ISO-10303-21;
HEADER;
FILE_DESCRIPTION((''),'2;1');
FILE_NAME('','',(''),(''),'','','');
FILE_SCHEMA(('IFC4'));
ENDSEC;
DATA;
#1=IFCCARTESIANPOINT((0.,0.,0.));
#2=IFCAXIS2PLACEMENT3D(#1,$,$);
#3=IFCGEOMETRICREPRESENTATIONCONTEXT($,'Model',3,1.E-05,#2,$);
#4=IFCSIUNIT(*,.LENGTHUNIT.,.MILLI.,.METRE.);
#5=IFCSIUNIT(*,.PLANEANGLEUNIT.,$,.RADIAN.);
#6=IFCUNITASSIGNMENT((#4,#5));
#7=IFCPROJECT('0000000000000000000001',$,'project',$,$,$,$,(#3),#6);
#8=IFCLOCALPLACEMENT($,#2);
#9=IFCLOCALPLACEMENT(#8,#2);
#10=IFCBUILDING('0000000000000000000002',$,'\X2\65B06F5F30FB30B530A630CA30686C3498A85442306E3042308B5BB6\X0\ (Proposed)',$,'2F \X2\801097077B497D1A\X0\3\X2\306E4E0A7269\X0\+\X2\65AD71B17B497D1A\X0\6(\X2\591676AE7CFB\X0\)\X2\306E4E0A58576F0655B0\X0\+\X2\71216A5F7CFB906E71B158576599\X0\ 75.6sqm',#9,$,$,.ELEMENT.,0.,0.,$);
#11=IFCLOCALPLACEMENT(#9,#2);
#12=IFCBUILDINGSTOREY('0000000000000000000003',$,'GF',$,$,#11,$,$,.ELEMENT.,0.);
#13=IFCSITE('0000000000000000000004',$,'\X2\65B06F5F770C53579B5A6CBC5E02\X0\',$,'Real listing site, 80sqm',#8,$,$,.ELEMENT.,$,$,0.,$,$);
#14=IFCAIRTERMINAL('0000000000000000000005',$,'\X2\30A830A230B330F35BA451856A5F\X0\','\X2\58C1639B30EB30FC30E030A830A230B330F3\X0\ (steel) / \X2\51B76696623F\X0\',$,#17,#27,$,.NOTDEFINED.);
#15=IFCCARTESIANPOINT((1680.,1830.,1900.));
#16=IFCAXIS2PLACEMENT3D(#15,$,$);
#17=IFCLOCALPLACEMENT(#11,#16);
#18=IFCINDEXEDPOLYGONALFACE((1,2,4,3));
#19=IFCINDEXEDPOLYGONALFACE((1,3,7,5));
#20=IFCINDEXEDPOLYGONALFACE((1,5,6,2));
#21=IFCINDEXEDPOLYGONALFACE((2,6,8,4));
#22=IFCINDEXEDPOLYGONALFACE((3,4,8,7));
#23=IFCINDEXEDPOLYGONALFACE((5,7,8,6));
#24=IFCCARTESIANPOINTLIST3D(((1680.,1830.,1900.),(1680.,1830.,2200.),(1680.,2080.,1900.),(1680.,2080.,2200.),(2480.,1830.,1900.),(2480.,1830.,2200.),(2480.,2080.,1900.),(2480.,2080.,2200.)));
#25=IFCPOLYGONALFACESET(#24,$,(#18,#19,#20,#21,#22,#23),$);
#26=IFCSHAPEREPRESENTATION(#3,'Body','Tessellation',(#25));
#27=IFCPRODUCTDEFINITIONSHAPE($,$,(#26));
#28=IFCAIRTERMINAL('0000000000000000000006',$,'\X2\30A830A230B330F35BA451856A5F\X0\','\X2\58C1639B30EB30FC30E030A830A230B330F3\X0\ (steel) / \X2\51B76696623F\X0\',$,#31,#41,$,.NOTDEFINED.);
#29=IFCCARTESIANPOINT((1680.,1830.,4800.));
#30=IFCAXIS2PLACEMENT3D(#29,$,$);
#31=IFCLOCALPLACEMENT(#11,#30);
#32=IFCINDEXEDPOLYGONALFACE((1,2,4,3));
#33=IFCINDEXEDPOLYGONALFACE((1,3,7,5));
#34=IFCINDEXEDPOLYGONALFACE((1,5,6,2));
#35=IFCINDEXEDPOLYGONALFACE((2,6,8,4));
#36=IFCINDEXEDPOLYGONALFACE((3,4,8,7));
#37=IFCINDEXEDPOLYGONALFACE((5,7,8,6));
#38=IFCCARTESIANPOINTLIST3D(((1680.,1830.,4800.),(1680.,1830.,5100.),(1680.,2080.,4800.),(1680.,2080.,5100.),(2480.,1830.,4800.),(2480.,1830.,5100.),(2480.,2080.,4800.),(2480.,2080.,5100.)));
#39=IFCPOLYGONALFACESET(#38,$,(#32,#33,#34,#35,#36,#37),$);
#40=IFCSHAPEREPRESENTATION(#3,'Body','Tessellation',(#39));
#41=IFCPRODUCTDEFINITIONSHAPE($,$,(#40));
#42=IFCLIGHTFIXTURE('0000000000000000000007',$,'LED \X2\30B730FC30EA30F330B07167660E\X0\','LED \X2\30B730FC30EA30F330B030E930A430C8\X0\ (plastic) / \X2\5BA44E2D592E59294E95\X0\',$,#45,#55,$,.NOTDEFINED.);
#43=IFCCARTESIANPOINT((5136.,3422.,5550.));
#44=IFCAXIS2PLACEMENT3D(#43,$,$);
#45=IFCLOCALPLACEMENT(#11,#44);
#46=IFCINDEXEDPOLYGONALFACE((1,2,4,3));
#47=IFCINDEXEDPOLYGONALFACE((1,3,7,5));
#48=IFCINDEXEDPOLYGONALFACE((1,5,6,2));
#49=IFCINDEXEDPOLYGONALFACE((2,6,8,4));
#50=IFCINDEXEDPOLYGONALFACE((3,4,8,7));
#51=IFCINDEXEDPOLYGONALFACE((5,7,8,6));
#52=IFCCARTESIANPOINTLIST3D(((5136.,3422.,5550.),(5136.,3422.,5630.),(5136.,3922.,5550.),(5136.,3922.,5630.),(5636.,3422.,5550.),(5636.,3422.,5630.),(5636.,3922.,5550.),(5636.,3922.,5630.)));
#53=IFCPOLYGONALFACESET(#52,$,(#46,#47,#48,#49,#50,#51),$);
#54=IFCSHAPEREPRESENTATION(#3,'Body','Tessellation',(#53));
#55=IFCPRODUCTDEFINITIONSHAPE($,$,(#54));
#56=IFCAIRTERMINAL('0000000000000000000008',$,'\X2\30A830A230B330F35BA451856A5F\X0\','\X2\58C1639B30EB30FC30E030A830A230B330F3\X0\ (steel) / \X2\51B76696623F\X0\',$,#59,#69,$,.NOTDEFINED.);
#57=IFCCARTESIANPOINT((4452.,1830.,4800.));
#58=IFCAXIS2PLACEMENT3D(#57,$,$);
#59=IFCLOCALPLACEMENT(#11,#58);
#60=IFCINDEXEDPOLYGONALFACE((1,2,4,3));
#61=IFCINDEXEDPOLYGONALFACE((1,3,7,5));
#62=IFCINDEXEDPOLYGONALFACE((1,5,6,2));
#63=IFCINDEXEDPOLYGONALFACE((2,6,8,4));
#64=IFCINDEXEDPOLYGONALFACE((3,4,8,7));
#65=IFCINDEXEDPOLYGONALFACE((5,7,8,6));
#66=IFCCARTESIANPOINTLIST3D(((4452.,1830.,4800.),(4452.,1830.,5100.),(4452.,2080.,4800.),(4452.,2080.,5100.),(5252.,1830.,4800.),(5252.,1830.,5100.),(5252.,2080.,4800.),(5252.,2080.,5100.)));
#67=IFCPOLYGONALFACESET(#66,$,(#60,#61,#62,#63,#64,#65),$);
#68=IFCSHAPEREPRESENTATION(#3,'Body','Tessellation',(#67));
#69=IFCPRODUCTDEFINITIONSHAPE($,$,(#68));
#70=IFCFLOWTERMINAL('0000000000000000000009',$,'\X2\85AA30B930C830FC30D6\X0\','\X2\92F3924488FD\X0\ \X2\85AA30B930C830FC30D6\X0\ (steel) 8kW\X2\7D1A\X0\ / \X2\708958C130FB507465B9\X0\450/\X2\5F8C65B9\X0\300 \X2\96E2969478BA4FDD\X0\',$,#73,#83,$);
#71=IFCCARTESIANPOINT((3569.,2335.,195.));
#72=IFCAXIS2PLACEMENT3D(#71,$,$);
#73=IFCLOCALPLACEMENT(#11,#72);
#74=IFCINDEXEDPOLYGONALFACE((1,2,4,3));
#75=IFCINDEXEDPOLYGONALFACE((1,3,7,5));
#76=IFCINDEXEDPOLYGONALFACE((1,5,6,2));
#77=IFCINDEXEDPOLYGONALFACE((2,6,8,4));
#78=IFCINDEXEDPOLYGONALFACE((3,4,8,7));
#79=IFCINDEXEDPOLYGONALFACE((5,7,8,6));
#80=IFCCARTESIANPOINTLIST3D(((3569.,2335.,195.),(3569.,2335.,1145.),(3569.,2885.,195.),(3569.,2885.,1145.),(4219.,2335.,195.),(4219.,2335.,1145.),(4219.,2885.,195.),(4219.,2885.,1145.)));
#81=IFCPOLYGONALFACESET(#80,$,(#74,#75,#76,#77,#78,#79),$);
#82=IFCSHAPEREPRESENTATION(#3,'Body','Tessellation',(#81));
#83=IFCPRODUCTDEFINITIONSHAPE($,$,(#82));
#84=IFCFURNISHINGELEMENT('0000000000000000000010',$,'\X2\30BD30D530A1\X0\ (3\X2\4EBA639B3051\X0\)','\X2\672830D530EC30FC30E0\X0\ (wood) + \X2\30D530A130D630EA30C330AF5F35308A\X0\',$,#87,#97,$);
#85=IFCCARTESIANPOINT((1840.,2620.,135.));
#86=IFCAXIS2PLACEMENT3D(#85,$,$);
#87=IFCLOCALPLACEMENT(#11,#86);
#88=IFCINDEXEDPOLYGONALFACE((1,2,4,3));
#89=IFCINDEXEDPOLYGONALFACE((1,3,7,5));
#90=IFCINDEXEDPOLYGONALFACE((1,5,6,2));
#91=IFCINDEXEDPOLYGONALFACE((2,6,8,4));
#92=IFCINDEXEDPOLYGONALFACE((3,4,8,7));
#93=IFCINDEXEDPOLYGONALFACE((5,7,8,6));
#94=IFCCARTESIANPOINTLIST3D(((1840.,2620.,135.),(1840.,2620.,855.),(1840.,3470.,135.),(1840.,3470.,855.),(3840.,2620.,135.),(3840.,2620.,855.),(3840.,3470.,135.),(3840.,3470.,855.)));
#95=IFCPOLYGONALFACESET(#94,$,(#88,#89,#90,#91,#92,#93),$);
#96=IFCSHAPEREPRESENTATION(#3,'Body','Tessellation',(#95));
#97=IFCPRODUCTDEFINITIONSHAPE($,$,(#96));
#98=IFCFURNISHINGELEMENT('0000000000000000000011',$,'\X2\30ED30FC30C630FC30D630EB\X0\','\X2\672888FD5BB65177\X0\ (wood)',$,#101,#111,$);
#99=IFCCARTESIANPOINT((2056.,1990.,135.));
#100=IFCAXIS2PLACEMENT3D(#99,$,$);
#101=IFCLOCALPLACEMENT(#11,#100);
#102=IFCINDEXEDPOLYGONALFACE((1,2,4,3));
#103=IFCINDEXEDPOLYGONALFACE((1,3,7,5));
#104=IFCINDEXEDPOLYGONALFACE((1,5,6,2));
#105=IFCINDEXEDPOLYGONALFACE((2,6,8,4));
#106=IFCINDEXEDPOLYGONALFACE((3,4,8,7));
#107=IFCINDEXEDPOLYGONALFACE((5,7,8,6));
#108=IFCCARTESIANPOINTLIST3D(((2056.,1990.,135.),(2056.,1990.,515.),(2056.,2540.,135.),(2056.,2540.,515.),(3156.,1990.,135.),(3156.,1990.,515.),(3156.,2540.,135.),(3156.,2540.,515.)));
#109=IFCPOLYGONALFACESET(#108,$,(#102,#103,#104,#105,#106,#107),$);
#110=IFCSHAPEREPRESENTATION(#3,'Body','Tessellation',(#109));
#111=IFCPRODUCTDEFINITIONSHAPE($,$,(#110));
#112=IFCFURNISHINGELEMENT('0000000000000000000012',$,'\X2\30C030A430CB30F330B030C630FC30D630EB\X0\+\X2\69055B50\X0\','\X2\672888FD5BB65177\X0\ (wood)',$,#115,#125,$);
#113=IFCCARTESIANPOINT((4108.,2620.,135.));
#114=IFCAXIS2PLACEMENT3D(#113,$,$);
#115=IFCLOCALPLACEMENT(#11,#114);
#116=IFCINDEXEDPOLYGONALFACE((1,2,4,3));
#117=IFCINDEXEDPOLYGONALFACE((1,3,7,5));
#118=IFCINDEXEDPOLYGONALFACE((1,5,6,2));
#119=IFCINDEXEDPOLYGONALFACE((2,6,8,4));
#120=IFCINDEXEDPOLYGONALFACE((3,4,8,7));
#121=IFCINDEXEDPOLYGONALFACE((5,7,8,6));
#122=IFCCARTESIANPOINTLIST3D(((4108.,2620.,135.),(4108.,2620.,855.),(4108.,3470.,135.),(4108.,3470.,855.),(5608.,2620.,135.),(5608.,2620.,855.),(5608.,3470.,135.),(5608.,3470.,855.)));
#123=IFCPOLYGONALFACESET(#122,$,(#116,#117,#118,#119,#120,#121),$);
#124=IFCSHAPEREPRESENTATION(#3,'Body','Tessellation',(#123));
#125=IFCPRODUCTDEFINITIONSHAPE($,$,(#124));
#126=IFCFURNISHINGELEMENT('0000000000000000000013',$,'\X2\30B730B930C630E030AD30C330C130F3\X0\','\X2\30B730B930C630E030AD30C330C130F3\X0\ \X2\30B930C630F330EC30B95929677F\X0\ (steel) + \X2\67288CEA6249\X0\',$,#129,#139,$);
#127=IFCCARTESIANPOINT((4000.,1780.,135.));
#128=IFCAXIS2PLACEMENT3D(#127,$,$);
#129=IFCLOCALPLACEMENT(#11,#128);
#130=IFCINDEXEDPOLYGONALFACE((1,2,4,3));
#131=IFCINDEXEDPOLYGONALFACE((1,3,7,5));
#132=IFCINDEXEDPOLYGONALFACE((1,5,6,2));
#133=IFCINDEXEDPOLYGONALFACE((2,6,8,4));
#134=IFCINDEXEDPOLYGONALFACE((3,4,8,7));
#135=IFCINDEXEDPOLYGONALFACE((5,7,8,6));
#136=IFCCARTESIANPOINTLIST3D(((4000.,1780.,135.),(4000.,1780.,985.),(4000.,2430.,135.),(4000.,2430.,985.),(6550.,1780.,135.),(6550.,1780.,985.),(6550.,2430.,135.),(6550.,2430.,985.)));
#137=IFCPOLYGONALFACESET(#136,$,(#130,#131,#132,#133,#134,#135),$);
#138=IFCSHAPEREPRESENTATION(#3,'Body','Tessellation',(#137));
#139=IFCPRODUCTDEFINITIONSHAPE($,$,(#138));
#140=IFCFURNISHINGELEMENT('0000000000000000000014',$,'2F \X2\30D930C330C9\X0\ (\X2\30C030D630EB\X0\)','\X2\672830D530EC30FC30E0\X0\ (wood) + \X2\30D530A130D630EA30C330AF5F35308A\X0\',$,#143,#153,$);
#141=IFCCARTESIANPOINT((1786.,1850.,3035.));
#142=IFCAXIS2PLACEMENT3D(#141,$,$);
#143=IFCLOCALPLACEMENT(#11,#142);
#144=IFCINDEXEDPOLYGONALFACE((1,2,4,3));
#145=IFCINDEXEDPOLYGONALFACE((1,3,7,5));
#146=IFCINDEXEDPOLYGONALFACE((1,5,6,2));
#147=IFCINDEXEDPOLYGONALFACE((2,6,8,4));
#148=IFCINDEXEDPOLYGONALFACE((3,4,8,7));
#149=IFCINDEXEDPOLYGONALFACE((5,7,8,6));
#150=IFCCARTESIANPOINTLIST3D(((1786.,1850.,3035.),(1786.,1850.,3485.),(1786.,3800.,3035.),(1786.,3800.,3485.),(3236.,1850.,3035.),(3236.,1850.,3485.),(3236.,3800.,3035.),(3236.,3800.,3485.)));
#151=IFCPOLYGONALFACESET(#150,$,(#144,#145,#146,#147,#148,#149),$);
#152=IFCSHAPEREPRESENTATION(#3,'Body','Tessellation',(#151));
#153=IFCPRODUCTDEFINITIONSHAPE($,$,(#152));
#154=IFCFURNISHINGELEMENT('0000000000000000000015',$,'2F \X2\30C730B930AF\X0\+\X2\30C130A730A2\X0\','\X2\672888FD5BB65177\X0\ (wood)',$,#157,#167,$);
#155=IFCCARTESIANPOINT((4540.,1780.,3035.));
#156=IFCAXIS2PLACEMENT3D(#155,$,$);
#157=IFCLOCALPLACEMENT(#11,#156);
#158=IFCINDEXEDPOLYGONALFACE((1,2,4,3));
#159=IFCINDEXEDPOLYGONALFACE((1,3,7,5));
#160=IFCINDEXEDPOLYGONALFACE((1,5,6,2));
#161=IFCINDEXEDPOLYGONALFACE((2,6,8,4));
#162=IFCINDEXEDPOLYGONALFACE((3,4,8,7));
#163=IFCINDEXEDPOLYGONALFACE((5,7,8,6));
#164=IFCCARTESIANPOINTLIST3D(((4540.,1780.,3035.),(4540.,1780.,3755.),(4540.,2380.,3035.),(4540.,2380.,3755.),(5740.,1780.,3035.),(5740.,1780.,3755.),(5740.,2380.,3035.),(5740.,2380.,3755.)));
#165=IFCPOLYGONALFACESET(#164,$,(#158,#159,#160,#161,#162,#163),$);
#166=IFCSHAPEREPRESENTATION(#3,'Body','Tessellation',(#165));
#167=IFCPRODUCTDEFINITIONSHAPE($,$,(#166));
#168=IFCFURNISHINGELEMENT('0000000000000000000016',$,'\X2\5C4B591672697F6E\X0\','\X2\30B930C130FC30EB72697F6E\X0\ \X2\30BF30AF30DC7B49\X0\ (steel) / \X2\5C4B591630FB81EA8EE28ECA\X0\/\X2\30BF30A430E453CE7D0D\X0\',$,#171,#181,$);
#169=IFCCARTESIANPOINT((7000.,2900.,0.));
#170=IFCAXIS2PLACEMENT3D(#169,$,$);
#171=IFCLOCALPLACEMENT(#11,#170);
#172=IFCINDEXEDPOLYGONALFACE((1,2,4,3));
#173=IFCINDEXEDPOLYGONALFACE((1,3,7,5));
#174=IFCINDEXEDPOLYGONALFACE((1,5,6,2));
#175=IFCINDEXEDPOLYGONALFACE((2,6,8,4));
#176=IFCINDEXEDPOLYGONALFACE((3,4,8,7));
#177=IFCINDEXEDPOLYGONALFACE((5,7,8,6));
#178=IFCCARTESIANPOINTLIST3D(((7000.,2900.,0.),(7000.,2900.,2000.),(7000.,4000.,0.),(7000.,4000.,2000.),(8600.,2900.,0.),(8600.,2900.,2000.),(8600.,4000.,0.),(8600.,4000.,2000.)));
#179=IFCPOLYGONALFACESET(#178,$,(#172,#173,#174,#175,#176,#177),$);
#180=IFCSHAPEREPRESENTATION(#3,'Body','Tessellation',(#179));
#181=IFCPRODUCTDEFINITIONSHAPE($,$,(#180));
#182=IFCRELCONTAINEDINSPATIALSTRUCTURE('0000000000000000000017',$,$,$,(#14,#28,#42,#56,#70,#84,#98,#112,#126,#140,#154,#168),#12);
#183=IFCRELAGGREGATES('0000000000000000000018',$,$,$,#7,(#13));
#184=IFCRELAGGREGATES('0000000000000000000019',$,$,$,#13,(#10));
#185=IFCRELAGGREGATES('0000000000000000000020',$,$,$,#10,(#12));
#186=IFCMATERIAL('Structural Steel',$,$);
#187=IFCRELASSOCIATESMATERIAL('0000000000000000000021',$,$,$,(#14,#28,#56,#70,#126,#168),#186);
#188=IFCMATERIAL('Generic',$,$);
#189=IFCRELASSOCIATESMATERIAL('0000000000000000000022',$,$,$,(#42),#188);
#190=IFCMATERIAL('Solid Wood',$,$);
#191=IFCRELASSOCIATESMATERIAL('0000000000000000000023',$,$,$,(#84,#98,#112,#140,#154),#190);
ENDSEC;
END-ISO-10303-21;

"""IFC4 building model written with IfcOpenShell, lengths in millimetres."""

from ifc_helpers import new_model, si_unit, frame, frame_2d, origin, place, context, project, spatial, rectangle, extrude, material, element, save


model = new_model("IFC4")

# Units and contexts
model_context = context("Model", 3, precision=1e-05, world=origin())
ifc_project = project(units=[si_unit("LENGTHUNIT", "METRE", prefix="MILLI"), si_unit("PLANEANGLEUNIT", "RADIAN")], contexts=[model_context])

# Site, building, storey
site_placement = place(None, origin())
site = spatial("IfcSite", under=ifc_project, at=site_placement, Name="新潟県南魚沼市", ObjectType="Real listing site, 80sqm", CompositionType="ELEMENT", RefElevation=0.0)
building_placement = place(site_placement, origin())
building = spatial("IfcBuilding", under=site, at=building_placement, Name="新潟・サウナと水風呂のある家 (Proposed)", ObjectType="2F 耐震等級3の上物+断熱等級6(外皮系)の上塗漆喰+無機系遮熱塗料 75.6sqm", CompositionType="ELEMENT", ElevationOfRefHeight=0.0, ElevationOfTerrain=0.0)
storey_placement = place(building_placement, origin())
storey = spatial("IfcBuildingStorey", under=building, at=storey_placement, Name="GF", CompositionType="ELEMENT", Elevation=0.0)

# Shared definitions
ifc_material_1 = material(Name="Solid Wood")

# Shared definitions
ifc_material_2 = material(Name="Structural Steel")

# Shared definitions
ifc_material_3 = material(Name="Generic")

# Air terminals
air_terminal_1_placement = place(storey_placement, frame((1680.0, 1830.0, 1900.0)))
element("IfcAirTerminal", 1, at=air_terminal_1_placement, inside=storey, material=ifc_material_2, Name="エアコン室内機", Description="壁掛ルームエアコン (steel) / 冷暖房", PredefinedType="NOTDEFINED", context=model_context, shape_type="SweptSolid", body=[
    extrude(rectangle(XDim=800.0, YDim=250.0, at=frame_2d((400.0, 125.0))), frame((1680.0, 1830.0, 1900.0)), (0.0, 0.0, 1.0), 300.0),
])
air_terminal_2_placement = place(storey_placement, frame((1680.0, 1830.0, 4800.0)))
element("IfcAirTerminal", 2, at=air_terminal_2_placement, inside=storey, material=ifc_material_2, Name="エアコン室内機", Description="壁掛ルームエアコン (steel) / 冷暖房", PredefinedType="NOTDEFINED", context=model_context, shape_type="SweptSolid", body=[
    extrude(rectangle(XDim=800.0, YDim=250.0, at=frame_2d((400.0, 125.0))), frame((1680.0, 1830.0, 4800.0)), (0.0, 0.0, 1.0), 300.0),
])

# Light fixture
light_fixture_placement = place(storey_placement, frame((5136.0, 3422.0, 5550.0)))
element("IfcLightFixture", 3, at=light_fixture_placement, inside=storey, material=ifc_material_3, Name="LED シーリング照明", Description="LED シーリングライト (plastic) / 室中央天井", PredefinedType="NOTDEFINED", context=model_context, shape_type="SweptSolid", body=[
    extrude(rectangle(XDim=500.0, YDim=500.0, at=frame_2d((250.0, 250.0))), frame((5136.0, 3422.0, 5550.0)), (0.0, 0.0, 1.0), 80.0),
])

# Air terminal
air_terminal_3_placement = place(storey_placement, frame((4452.0, 1830.0, 4800.0)))
element("IfcAirTerminal", 4, at=air_terminal_3_placement, inside=storey, material=ifc_material_2, Name="エアコン室内機", Description="壁掛ルームエアコン (steel) / 冷暖房", PredefinedType="NOTDEFINED", context=model_context, shape_type="SweptSolid", body=[
    extrude(rectangle(XDim=800.0, YDim=250.0, at=frame_2d((400.0, 125.0))), frame((4452.0, 1830.0, 4800.0)), (0.0, 0.0, 1.0), 300.0),
])

# Flow terminal
flow_terminal_1_placement = place(storey_placement, frame((3569.0, 2335.0, 195.0)))
element("IfcFlowTerminal", 5, at=flow_terminal_1_placement, inside=storey, material=ifc_material_2, Name="薪ストーブ", Description="鋳鉄製 薪ストーブ (steel) 8kW級 / 炉壁・側方450/後方300 離隔確保", context=model_context, shape_type="SweptSolid", body=[
    extrude(rectangle(XDim=650.0, YDim=550.0, at=frame_2d((325.0, 275.0))), frame((3569.0, 2335.0, 195.0)), (0.0, 0.0, 1.0), 950.0),
])

# Furnishing elements
furnishing_1_placement = place(storey_placement, frame((1840.0, 2620.0, 135.0)))
element("IfcFurnishingElement", 6, at=furnishing_1_placement, inside=storey, material=ifc_material_1, Name="ソファ (3人掛け)", Description="木フレーム (wood) + ファブリック張り", context=model_context, shape_type="SweptSolid", body=[
    extrude(rectangle(XDim=2000.0, YDim=850.0, at=frame_2d((1000.0, 425.0))), frame((1840.0, 2620.0, 135.0)), (0.0, 0.0, 1.0), 720.0),
])
furnishing_2_placement = place(storey_placement, frame((2056.0, 1990.0, 135.0)))
element("IfcFurnishingElement", 7, at=furnishing_2_placement, inside=storey, material=ifc_material_1, Name="ローテーブル", Description="木製家具 (wood)", context=model_context, shape_type="SweptSolid", body=[
    extrude(rectangle(XDim=1100.0, YDim=550.0, at=frame_2d((550.0, 275.0))), frame((2056.0, 1990.0, 135.0)), (0.0, 0.0, 1.0), 380.0),
])
furnishing_3_placement = place(storey_placement, frame((4108.0, 2620.0, 135.0)))
element("IfcFurnishingElement", 8, at=furnishing_3_placement, inside=storey, material=ifc_material_1, Name="ダイニングテーブル+椅子", Description="木製家具 (wood)", context=model_context, shape_type="SweptSolid", body=[
    extrude(rectangle(XDim=1500.0, YDim=850.0, at=frame_2d((750.0, 425.0))), frame((4108.0, 2620.0, 135.0)), (0.0, 0.0, 1.0), 720.0),
])
furnishing_4_placement = place(storey_placement, frame((4000.0, 1780.0, 135.0)))
element("IfcFurnishingElement", 9, at=furnishing_4_placement, inside=storey, material=ifc_material_2, Name="システムキッチン", Description="システムキッチン ステンレス天板 (steel) + 木質扉", context=model_context, shape_type="SweptSolid", body=[
    extrude(rectangle(XDim=2550.0, YDim=650.0, at=frame_2d((1275.0, 325.0))), frame((4000.0, 1780.0, 135.0)), (0.0, 0.0, 1.0), 850.0),
])
furnishing_5_placement = place(storey_placement, frame((1786.0, 1850.0, 3035.0)))
element("IfcFurnishingElement", 10, at=furnishing_5_placement, inside=storey, material=ifc_material_1, Name="2F ベッド (ダブル)", Description="木フレーム (wood) + ファブリック張り", context=model_context, shape_type="SweptSolid", body=[
    extrude(rectangle(XDim=1450.0, YDim=1950.0, at=frame_2d((725.0, 975.0))), frame((1786.0, 1850.0, 3035.0)), (0.0, 0.0, 1.0), 450.0),
])
furnishing_6_placement = place(storey_placement, frame((4540.0, 1780.0, 3035.0)))
element("IfcFurnishingElement", 11, at=furnishing_6_placement, inside=storey, material=ifc_material_1, Name="2F デスク+チェア", Description="木製家具 (wood)", context=model_context, shape_type="SweptSolid", body=[
    extrude(rectangle(XDim=1200.0, YDim=600.0, at=frame_2d((600.0, 300.0))), frame((4540.0, 1780.0, 3035.0)), (0.0, 0.0, 1.0), 720.0),
])
furnishing_7_placement = place(storey_placement, frame((7000.0, 2900.0, 0.0)))
element("IfcFurnishingElement", 12, at=furnishing_7_placement, inside=storey, material=ifc_material_2, Name="屋外物置", Description="スチール物置 タクボ等 (steel) / 屋外・自転車/タイヤ収納", context=model_context, shape_type="SweptSolid", body=[
    extrude(rectangle(XDim=1600.0, YDim=1100.0, at=frame_2d((800.0, 550.0))), frame((7000.0, 2900.0, 0.0)), (0.0, 0.0, 1.0), 2000.0),
])

save(model, "model.ifc")
